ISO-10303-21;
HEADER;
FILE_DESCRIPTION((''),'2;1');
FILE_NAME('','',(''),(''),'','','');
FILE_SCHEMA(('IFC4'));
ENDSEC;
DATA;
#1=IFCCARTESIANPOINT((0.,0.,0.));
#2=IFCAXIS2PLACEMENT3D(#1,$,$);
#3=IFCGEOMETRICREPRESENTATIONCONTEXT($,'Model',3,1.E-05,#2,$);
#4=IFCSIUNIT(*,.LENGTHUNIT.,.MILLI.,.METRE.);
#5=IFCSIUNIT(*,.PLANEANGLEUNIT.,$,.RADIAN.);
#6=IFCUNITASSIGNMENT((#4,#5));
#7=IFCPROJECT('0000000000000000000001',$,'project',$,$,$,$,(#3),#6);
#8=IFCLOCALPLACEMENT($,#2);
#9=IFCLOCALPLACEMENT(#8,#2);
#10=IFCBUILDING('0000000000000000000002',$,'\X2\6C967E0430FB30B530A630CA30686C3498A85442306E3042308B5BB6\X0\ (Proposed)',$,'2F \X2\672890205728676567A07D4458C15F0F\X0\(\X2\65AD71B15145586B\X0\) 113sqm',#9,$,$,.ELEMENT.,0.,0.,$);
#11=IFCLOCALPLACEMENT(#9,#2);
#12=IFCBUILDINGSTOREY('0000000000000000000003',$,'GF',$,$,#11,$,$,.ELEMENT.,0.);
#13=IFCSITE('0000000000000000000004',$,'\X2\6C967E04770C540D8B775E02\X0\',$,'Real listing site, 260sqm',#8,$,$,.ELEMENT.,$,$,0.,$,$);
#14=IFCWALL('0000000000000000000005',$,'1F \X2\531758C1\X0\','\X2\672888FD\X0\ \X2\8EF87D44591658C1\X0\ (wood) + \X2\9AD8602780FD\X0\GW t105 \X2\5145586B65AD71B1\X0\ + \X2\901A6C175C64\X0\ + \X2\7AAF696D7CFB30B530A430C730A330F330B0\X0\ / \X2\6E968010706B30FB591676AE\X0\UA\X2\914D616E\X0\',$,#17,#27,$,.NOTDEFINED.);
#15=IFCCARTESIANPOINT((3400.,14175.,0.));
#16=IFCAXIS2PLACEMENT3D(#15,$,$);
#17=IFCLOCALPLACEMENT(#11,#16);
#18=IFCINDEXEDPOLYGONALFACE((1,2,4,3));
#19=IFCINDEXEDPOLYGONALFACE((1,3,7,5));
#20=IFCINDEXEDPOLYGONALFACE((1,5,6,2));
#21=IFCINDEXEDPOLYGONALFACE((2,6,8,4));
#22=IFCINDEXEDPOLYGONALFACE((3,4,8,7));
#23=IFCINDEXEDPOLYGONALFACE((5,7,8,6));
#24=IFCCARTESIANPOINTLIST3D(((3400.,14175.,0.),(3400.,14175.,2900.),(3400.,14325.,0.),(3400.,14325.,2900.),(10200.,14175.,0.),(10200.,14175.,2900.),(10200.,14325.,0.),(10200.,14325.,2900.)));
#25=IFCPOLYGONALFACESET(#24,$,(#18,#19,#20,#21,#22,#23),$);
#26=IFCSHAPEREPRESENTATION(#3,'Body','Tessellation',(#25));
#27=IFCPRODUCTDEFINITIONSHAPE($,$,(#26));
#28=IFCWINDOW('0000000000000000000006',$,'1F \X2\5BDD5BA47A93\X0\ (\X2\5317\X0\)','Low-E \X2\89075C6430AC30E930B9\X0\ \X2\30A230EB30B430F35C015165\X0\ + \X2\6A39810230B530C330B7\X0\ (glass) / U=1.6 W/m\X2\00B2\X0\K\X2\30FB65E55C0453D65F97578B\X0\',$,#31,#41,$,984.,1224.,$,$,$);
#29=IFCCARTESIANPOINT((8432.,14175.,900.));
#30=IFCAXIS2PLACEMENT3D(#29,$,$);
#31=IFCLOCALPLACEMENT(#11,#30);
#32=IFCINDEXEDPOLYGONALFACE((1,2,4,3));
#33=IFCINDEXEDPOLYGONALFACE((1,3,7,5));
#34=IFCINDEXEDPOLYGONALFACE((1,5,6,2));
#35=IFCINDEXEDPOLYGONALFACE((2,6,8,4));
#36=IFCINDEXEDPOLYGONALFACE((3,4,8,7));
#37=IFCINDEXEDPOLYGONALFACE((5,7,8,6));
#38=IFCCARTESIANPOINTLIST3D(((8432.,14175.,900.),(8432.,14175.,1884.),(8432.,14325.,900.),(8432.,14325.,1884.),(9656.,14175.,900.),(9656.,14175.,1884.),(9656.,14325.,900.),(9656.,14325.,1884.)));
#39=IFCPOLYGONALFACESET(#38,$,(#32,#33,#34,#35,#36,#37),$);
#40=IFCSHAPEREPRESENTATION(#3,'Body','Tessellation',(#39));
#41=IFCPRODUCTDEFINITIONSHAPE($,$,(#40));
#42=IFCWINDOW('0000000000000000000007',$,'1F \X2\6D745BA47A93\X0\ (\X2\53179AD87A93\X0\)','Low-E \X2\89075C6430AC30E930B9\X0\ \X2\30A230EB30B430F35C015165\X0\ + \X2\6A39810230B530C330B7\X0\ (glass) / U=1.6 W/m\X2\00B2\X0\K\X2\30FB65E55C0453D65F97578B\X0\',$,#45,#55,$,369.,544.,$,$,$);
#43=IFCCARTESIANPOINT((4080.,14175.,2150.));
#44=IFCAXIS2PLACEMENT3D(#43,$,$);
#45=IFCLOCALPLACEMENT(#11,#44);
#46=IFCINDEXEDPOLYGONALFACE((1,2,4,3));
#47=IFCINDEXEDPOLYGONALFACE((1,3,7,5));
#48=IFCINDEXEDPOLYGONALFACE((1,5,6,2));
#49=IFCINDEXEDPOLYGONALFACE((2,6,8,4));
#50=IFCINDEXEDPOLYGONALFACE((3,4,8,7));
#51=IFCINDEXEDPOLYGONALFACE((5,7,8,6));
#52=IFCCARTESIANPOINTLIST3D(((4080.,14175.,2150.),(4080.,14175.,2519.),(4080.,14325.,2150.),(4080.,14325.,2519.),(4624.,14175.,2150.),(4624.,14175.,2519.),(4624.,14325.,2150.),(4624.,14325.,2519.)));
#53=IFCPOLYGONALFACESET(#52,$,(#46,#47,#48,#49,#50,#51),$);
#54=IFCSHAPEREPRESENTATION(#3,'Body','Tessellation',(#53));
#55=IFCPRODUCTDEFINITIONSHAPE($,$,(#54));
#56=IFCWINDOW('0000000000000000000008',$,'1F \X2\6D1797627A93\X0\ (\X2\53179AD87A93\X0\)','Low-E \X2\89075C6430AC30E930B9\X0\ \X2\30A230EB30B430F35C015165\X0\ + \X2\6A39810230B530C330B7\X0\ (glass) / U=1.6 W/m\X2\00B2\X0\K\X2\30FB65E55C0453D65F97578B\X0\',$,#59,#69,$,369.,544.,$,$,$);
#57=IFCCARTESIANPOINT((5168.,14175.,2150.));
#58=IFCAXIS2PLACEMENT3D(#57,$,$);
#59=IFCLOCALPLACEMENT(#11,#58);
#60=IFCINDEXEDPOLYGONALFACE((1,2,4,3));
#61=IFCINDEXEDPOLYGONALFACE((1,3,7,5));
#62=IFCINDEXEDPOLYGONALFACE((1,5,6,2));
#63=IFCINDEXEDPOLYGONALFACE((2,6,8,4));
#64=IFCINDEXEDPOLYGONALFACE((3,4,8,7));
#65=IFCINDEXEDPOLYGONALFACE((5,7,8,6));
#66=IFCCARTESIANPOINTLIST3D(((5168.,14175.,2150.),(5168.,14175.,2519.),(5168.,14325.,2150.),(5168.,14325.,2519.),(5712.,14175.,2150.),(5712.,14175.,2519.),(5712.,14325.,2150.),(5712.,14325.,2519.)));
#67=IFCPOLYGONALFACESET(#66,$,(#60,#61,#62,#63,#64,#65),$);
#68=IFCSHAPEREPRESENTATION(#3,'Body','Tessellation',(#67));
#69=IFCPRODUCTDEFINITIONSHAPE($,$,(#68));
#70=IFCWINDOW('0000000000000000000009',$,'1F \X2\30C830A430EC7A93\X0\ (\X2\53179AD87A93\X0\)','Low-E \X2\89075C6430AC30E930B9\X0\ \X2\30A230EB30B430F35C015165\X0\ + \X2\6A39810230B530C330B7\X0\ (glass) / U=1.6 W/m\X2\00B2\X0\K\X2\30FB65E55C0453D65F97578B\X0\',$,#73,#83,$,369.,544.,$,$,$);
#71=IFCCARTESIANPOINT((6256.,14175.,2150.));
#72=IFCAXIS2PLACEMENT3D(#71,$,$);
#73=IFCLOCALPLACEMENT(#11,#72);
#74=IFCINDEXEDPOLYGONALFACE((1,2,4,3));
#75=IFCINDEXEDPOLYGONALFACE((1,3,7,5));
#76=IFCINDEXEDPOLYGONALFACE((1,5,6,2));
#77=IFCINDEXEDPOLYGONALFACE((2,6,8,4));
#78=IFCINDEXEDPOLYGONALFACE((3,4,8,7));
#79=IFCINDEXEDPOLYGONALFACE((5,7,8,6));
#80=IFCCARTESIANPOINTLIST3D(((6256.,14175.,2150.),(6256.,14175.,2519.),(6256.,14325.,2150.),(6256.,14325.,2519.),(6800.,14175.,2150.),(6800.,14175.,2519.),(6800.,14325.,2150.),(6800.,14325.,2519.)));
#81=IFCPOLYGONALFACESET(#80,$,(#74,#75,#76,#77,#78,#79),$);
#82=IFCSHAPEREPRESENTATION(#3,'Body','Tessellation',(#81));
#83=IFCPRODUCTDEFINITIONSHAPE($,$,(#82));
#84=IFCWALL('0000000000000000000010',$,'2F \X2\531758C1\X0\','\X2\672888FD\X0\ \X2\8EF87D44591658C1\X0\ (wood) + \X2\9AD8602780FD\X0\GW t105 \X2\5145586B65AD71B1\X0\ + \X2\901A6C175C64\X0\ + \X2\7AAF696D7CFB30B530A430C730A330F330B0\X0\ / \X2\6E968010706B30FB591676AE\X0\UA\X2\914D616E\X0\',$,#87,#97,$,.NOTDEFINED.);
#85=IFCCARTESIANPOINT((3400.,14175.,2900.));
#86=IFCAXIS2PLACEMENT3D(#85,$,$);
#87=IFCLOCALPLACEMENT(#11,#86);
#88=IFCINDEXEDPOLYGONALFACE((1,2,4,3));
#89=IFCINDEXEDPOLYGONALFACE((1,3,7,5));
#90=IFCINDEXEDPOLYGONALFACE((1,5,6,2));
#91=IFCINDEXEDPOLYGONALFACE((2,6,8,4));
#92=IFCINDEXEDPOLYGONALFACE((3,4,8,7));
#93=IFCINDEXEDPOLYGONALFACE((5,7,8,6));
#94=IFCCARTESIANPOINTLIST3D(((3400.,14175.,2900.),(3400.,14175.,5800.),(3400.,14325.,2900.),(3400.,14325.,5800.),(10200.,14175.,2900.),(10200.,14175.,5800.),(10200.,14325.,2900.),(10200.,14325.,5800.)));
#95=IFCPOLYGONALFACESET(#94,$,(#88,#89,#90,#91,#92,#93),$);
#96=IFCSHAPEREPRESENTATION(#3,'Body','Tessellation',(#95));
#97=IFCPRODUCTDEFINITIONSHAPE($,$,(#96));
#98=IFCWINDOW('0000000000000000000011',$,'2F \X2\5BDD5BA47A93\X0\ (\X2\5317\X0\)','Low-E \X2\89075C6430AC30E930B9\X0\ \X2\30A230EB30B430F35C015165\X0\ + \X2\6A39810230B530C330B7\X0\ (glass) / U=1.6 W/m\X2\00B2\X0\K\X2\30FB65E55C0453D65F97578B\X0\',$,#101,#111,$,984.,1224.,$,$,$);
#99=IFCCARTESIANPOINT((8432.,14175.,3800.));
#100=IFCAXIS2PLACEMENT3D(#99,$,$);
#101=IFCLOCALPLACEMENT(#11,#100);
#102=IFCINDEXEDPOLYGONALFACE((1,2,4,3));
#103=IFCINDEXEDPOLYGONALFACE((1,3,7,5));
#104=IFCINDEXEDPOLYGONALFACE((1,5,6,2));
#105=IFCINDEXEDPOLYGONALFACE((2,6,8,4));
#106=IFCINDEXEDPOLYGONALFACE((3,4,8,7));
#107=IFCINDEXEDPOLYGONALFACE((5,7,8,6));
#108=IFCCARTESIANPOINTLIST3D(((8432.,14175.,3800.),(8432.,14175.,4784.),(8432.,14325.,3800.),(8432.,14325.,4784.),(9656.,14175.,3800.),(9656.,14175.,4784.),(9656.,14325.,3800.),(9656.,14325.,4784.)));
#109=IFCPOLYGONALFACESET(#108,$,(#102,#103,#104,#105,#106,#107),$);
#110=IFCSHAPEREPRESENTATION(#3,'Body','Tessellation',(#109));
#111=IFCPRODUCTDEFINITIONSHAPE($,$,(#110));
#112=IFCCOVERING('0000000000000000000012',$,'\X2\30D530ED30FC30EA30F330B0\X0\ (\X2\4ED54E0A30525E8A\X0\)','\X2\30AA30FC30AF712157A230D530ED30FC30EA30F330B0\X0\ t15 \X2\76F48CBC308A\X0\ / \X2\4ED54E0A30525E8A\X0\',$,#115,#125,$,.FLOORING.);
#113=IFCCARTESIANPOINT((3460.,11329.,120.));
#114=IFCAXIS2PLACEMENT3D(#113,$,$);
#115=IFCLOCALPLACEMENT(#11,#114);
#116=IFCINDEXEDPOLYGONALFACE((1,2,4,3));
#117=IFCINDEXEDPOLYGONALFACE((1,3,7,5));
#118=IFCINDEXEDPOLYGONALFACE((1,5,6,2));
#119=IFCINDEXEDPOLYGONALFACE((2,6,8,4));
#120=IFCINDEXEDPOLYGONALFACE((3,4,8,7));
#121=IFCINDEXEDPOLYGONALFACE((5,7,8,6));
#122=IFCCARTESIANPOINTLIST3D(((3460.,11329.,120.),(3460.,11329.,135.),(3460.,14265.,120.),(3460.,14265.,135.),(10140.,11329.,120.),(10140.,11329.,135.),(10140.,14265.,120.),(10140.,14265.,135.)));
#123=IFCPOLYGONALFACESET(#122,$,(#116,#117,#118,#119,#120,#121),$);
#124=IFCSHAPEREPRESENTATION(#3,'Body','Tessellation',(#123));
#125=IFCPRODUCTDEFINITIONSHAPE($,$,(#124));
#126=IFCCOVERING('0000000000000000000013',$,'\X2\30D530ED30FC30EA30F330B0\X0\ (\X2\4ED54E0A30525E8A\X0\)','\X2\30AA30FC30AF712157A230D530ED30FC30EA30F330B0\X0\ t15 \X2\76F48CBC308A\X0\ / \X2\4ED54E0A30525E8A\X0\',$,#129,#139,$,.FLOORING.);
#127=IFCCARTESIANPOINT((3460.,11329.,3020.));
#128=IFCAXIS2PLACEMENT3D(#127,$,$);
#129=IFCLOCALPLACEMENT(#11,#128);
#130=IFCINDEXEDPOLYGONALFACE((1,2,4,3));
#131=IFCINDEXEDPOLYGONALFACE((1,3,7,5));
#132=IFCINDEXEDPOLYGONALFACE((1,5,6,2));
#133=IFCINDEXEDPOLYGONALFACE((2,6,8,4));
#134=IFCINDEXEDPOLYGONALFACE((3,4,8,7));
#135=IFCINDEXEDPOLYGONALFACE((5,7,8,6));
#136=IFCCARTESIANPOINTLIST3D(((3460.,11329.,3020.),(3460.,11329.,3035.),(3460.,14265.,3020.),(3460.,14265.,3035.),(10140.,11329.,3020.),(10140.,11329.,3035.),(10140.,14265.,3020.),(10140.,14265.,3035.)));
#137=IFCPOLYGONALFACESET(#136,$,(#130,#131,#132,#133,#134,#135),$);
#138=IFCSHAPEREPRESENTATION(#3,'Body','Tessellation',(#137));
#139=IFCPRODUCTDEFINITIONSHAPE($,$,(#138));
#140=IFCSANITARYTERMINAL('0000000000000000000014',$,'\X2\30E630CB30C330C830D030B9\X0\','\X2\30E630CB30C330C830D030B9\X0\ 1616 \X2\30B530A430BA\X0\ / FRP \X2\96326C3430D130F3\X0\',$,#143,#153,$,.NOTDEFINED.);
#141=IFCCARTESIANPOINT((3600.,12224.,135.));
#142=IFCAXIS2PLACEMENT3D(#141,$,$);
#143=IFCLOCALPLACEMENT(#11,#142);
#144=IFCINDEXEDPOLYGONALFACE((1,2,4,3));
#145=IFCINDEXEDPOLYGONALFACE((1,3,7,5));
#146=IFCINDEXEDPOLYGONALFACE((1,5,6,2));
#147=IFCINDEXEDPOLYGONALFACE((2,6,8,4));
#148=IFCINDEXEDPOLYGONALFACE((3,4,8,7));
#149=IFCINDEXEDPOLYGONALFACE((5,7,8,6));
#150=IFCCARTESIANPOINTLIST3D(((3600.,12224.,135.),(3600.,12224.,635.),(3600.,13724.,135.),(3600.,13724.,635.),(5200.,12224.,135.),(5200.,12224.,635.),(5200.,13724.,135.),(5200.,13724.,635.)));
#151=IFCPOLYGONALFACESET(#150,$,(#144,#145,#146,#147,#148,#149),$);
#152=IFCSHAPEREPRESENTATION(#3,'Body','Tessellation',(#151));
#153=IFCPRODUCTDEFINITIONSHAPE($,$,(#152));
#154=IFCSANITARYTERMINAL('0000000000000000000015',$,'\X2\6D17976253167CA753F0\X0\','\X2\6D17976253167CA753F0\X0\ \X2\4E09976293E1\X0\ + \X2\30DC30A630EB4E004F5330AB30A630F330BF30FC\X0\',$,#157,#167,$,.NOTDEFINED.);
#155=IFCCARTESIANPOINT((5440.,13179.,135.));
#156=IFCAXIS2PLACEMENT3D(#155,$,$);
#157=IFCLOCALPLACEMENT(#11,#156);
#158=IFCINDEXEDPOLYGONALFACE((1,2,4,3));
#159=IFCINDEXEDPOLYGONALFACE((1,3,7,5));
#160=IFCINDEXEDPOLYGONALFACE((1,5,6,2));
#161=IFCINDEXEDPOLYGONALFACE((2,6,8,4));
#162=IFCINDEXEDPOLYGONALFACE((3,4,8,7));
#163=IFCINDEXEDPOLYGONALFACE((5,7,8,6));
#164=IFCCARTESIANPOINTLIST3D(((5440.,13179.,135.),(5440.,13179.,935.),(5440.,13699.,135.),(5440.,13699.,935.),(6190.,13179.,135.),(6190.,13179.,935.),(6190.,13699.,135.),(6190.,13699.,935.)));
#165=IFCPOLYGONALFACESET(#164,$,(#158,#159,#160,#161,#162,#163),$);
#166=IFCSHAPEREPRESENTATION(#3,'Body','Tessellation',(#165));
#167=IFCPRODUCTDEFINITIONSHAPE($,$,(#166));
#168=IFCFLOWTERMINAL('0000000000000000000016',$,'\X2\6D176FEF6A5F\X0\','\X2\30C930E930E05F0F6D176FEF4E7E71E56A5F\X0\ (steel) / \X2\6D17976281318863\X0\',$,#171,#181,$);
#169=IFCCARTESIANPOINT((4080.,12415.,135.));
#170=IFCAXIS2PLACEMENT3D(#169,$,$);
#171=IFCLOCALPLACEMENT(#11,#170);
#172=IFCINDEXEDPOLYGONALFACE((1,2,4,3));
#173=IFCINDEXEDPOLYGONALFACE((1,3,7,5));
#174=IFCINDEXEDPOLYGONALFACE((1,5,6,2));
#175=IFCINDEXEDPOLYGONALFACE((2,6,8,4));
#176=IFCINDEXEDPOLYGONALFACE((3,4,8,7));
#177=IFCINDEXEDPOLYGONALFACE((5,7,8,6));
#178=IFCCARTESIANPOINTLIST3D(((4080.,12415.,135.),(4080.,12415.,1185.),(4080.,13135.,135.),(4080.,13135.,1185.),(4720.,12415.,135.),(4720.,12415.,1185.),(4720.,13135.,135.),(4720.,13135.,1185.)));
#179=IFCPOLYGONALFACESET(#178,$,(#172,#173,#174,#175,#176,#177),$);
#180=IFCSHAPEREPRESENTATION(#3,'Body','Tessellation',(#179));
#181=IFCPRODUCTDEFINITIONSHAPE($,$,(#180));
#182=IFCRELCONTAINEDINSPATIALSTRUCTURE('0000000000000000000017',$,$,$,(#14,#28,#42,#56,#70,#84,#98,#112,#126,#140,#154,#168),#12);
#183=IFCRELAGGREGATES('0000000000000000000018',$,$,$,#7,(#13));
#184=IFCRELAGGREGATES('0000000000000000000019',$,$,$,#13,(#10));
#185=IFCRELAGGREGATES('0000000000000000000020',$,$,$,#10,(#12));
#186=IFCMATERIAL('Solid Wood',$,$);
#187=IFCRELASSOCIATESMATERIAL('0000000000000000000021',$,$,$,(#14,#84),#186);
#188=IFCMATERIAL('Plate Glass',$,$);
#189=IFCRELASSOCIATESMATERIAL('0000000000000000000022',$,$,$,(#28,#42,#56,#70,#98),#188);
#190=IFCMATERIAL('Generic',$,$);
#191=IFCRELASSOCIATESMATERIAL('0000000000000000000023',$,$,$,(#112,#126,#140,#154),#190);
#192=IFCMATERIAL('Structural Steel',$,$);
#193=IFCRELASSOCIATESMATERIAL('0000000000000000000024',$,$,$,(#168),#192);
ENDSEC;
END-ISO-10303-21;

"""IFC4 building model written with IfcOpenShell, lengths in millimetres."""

from ifc_helpers import new_model, si_unit, frame, frame_2d, origin, place, context, project, spatial, rectangle, extrude, material, element, fill, save


model = new_model("IFC4")

# Units and contexts
model_context = context("Model", 3, precision=1e-05, world=origin())
ifc_project = project(units=[si_unit("LENGTHUNIT", "METRE", prefix="MILLI"), si_unit("PLANEANGLEUNIT", "RADIAN")], contexts=[model_context])

# Site, building, storey
site_placement = place(None, origin())
site = spatial("IfcSite", under=ifc_project, at=site_placement, Name="沖縄県名護市", ObjectType="Real listing site, 260sqm", CompositionType="ELEMENT", RefElevation=0.0)
building_placement = place(site_placement, origin())
building = spatial("IfcBuilding", under=site, at=building_placement, Name="沖縄・サウナと水風呂のある家 (Proposed)", ObjectType="2F 木造在来枠組壁式(断熱充填) 113sqm", CompositionType="ELEMENT", ElevationOfRefHeight=0.0, ElevationOfTerrain=0.0)
storey_placement = place(building_placement, origin())
storey = spatial("IfcBuildingStorey", under=building, at=storey_placement, Name="GF", CompositionType="ELEMENT", Elevation=0.0)

# Shared definitions
ifc_material_1 = material(Name="Solid Wood")

# Wall, openings, windows
wall_1_placement = place(storey_placement, frame((3400.0, 14175.0, 0.0)))
wall_1 = element("IfcWall", 1, at=wall_1_placement, inside=storey, material=ifc_material_1, Name="1F 北壁", Description="木製 軸組外壁 (wood) + 高性能GW t105 充填断熱 + 通気層 + 窯業系サイディング / 準耐火・外皮UA配慮", PredefinedType="NOTDEFINED", context=model_context, shape_type="SweptSolid", body=[
    extrude(rectangle(XDim=6800.0, YDim=150.0, at=frame_2d((3400.0, 75.0))), frame((3400.0, 14175.0, 0.0)), (0.0, 0.0, 1.0), 2900.0),
])
opening_1_placement = place(storey_placement, frame((8432.0, 14175.0, 900.0)))
opening_1 = element("IfcOpeningElement", 2, at=opening_1_placement, cuts=wall_1, PredefinedType="NOTDEFINED", context=model_context, shape_type="SweptSolid", body=[
    extrude(rectangle(XDim=1224.0, YDim=150.0, at=frame_2d((612.0, 75.0))), frame((8432.0, 14175.0, 900.0)), (0.0, 0.0, 1.0), 984.0),
])
opening_2_placement = place(storey_placement, frame((4080.0, 14175.0, 2150.0)))
opening_2 = element("IfcOpeningElement", 3, at=opening_2_placement, cuts=wall_1, PredefinedType="NOTDEFINED", context=model_context, shape_type="SweptSolid", body=[
    extrude(rectangle(XDim=544.0, YDim=150.0, at=frame_2d((272.0, 75.0))), frame((4080.0, 14175.0, 2150.0)), (0.0, 0.0, 1.0), 369.0),
])
opening_3_placement = place(storey_placement, frame((5168.0, 14175.0, 2150.0)))
opening_3 = element("IfcOpeningElement", 4, at=opening_3_placement, cuts=wall_1, PredefinedType="NOTDEFINED", context=model_context, shape_type="SweptSolid", body=[
    extrude(rectangle(XDim=544.0, YDim=150.0, at=frame_2d((272.0, 75.0))), frame((5168.0, 14175.0, 2150.0)), (0.0, 0.0, 1.0), 369.0),
])
opening_4_placement = place(storey_placement, frame((6256.0, 14175.0, 2150.0)))
opening_4 = element("IfcOpeningElement", 5, at=opening_4_placement, cuts=wall_1, PredefinedType="NOTDEFINED", context=model_context, shape_type="SweptSolid", body=[
    extrude(rectangle(XDim=544.0, YDim=150.0, at=frame_2d((272.0, 75.0))), frame((6256.0, 14175.0, 2150.0)), (0.0, 0.0, 1.0), 369.0),
])
ifc_material_2 = material(Name="Plate Glass")
window_1_placement = place(storey_placement, frame((8432.0, 14175.0, 900.0)))
window_1 = element("IfcWindow", 6, at=window_1_placement, inside=storey, material=ifc_material_2, Name="1F 寝室窓 (北)", Description="Low-E 複層ガラス アルゴン封入 + 樹脂サッシ (glass) / U=1.6 W/m²K・日射取得型", OverallHeight=984.0, OverallWidth=1224.0, context=model_context, shape_type="SweptSolid", body=[
    extrude(rectangle(XDim=1224.0, YDim=150.0, at=frame_2d((612.0, 75.0))), frame((8432.0, 14175.0, 900.0)), (0.0, 0.0, 1.0), 984.0),
])
fill(opening_1, window_1)
window_2_placement = place(storey_placement, frame((4080.0, 14175.0, 2150.0)))
window_2 = element("IfcWindow", 7, at=window_2_placement, inside=storey, material=ifc_material_2, Name="1F 浴室窓 (北高窓)", Description="Low-E 複層ガラス アルゴン封入 + 樹脂サッシ (glass) / U=1.6 W/m²K・日射取得型", OverallHeight=369.0, OverallWidth=544.0, context=model_context, shape_type="SweptSolid", body=[
    extrude(rectangle(XDim=544.0, YDim=150.0, at=frame_2d((272.0, 75.0))), frame((4080.0, 14175.0, 2150.0)), (0.0, 0.0, 1.0), 369.0),
])
fill(opening_2, window_2)
window_3_placement = place(storey_placement, frame((5168.0, 14175.0, 2150.0)))
window_3 = element("IfcWindow", 8, at=window_3_placement, inside=storey, material=ifc_material_2, Name="1F 洗面窓 (北高窓)", Description="Low-E 複層ガラス アルゴン封入 + 樹脂サッシ (glass) / U=1.6 W/m²K・日射取得型", OverallHeight=369.0, OverallWidth=544.0, context=model_context, shape_type="SweptSolid", body=[
    extrude(rectangle(XDim=544.0, YDim=150.0, at=frame_2d((272.0, 75.0))), frame((5168.0, 14175.0, 2150.0)), (0.0, 0.0, 1.0), 369.0),
])
fill(opening_3, window_3)
window_4_placement = place(storey_placement, frame((6256.0, 14175.0, 2150.0)))
window_4 = element("IfcWindow", 9, at=window_4_placement, inside=storey, material=ifc_material_2, Name="1F トイレ窓 (北高窓)", Description="Low-E 複層ガラス アルゴン封入 + 樹脂サッシ (glass) / U=1.6 W/m²K・日射取得型", OverallHeight=369.0, OverallWidth=544.0, context=model_context, shape_type="SweptSolid", body=[
    extrude(rectangle(XDim=544.0, YDim=150.0, at=frame_2d((272.0, 75.0))), frame((6256.0, 14175.0, 2150.0)), (0.0, 0.0, 1.0), 369.0),
])
fill(opening_4, window_4)

# Wall, opening, window
wall_2_placement = place(storey_placement, frame((3400.0, 14175.0, 2900.0)))
wall_2 = element("IfcWall", 10, at=wall_2_placement, inside=storey, material=ifc_material_1, Name="2F 北壁", Description="木製 軸組外壁 (wood) + 高性能GW t105 充填断熱 + 通気層 + 窯業系サイディング / 準耐火・外皮UA配慮", PredefinedType="NOTDEFINED", context=model_context, shape_type="SweptSolid", body=[
    extrude(rectangle(XDim=6800.0, YDim=150.0, at=frame_2d((3400.0, 75.0))), frame((3400.0, 14175.0, 2900.0)), (0.0, 0.0, 1.0), 2900.0),
])
opening_5_placement = place(storey_placement, frame((8432.0, 14175.0, 3800.0)))
opening_5 = element("IfcOpeningElement", 11, at=opening_5_placement, cuts=wall_2, PredefinedType="NOTDEFINED", context=model_context, shape_type="SweptSolid", body=[
    extrude(rectangle(XDim=1224.0, YDim=150.0, at=frame_2d((612.0, 75.0))), frame((8432.0, 14175.0, 3800.0)), (0.0, 0.0, 1.0), 984.0),
])
window_5_placement = place(storey_placement, frame((8432.0, 14175.0, 3800.0)))
window_5 = element("IfcWindow", 12, at=window_5_placement, inside=storey, material=ifc_material_2, Name="2F 寝室窓 (北)", Description="Low-E 複層ガラス アルゴン封入 + 樹脂サッシ (glass) / U=1.6 W/m²K・日射取得型", OverallHeight=984.0, OverallWidth=1224.0, context=model_context, shape_type="SweptSolid", body=[
    extrude(rectangle(XDim=1224.0, YDim=150.0, at=frame_2d((612.0, 75.0))), frame((8432.0, 14175.0, 3800.0)), (0.0, 0.0, 1.0), 984.0),
])
fill(opening_5, window_5)

# Coverings
ifc_material_3 = material(Name="Generic")
covering_1_placement = place(storey_placement, frame((3460.0, 11329.0, 120.0)))
element("IfcCovering", 13, at=covering_1_placement, inside=storey, material=ifc_material_3, Name="フローリング (仕上げ床)", Description="オーク無垢フローリング t15 直貼り / 仕上げ床", PredefinedType="FLOORING", context=model_context, shape_type="SweptSolid", body=[
    extrude(rectangle(XDim=6680.0, YDim=2936.0, at=frame_2d((3340.0, 1468.0))), frame((3460.0, 11329.0, 120.0)), (0.0, 0.0, 1.0), 15.0),
])
covering_2_placement = place(storey_placement, frame((3460.0, 11329.0, 3020.0)))
element("IfcCovering", 14, at=covering_2_placement, inside=storey, material=ifc_material_3, Name="フローリング (仕上げ床)", Description="オーク無垢フローリング t15 直貼り / 仕上げ床", PredefinedType="FLOORING", context=model_context, shape_type="SweptSolid", body=[
    extrude(rectangle(XDim=6680.0, YDim=2936.0, at=frame_2d((3340.0, 1468.0))), frame((3460.0, 11329.0, 3020.0)), (0.0, 0.0, 1.0), 15.0),
])

# Sanitary terminals
sanitary_terminal_1_placement = place(storey_placement, frame((3600.0, 12224.0, 135.0)))
element("IfcSanitaryTerminal", 15, at=sanitary_terminal_1_placement, inside=storey, material=ifc_material_3, Name="ユニットバス", Description="ユニットバス 1616 サイズ / FRP 防水パン", PredefinedType="NOTDEFINED", context=model_context, shape_type="SweptSolid", body=[
    extrude(rectangle(XDim=1600.0, YDim=1500.0, at=frame_2d((800.0, 750.0))), frame((3600.0, 12224.0, 135.0)), (0.0, 0.0, 1.0), 500.0),
])
sanitary_terminal_2_placement = place(storey_placement, frame((5440.0, 13179.0, 135.0)))
element("IfcSanitaryTerminal", 16, at=sanitary_terminal_2_placement, inside=storey, material=ifc_material_3, Name="洗面化粧台", Description="洗面化粧台 三面鏡 + ボウル一体カウンター", PredefinedType="NOTDEFINED", context=model_context, shape_type="SweptSolid", body=[
    extrude(rectangle(XDim=750.0, YDim=520.0, at=frame_2d((375.0, 260.0))), frame((5440.0, 13179.0, 135.0)), (0.0, 0.0, 1.0), 800.0),
])

# Flow terminal
ifc_material_4 = material(Name="Structural Steel")
flow_terminal_placement = place(storey_placement, frame((4080.0, 12415.0, 135.0)))
element("IfcFlowTerminal", 17, at=flow_terminal_placement, inside=storey, material=ifc_material_4, Name="洗濯機", Description="ドラム式洗濯乾燥機 (steel) / 洗面脱衣", context=model_context, shape_type="SweptSolid", body=[
    extrude(rectangle(XDim=640.0, YDim=720.0, at=frame_2d((320.0, 360.0))), frame((4080.0, 12415.0, 135.0)), (0.0, 0.0, 1.0), 1050.0),
])

save(model, "model.ifc")
